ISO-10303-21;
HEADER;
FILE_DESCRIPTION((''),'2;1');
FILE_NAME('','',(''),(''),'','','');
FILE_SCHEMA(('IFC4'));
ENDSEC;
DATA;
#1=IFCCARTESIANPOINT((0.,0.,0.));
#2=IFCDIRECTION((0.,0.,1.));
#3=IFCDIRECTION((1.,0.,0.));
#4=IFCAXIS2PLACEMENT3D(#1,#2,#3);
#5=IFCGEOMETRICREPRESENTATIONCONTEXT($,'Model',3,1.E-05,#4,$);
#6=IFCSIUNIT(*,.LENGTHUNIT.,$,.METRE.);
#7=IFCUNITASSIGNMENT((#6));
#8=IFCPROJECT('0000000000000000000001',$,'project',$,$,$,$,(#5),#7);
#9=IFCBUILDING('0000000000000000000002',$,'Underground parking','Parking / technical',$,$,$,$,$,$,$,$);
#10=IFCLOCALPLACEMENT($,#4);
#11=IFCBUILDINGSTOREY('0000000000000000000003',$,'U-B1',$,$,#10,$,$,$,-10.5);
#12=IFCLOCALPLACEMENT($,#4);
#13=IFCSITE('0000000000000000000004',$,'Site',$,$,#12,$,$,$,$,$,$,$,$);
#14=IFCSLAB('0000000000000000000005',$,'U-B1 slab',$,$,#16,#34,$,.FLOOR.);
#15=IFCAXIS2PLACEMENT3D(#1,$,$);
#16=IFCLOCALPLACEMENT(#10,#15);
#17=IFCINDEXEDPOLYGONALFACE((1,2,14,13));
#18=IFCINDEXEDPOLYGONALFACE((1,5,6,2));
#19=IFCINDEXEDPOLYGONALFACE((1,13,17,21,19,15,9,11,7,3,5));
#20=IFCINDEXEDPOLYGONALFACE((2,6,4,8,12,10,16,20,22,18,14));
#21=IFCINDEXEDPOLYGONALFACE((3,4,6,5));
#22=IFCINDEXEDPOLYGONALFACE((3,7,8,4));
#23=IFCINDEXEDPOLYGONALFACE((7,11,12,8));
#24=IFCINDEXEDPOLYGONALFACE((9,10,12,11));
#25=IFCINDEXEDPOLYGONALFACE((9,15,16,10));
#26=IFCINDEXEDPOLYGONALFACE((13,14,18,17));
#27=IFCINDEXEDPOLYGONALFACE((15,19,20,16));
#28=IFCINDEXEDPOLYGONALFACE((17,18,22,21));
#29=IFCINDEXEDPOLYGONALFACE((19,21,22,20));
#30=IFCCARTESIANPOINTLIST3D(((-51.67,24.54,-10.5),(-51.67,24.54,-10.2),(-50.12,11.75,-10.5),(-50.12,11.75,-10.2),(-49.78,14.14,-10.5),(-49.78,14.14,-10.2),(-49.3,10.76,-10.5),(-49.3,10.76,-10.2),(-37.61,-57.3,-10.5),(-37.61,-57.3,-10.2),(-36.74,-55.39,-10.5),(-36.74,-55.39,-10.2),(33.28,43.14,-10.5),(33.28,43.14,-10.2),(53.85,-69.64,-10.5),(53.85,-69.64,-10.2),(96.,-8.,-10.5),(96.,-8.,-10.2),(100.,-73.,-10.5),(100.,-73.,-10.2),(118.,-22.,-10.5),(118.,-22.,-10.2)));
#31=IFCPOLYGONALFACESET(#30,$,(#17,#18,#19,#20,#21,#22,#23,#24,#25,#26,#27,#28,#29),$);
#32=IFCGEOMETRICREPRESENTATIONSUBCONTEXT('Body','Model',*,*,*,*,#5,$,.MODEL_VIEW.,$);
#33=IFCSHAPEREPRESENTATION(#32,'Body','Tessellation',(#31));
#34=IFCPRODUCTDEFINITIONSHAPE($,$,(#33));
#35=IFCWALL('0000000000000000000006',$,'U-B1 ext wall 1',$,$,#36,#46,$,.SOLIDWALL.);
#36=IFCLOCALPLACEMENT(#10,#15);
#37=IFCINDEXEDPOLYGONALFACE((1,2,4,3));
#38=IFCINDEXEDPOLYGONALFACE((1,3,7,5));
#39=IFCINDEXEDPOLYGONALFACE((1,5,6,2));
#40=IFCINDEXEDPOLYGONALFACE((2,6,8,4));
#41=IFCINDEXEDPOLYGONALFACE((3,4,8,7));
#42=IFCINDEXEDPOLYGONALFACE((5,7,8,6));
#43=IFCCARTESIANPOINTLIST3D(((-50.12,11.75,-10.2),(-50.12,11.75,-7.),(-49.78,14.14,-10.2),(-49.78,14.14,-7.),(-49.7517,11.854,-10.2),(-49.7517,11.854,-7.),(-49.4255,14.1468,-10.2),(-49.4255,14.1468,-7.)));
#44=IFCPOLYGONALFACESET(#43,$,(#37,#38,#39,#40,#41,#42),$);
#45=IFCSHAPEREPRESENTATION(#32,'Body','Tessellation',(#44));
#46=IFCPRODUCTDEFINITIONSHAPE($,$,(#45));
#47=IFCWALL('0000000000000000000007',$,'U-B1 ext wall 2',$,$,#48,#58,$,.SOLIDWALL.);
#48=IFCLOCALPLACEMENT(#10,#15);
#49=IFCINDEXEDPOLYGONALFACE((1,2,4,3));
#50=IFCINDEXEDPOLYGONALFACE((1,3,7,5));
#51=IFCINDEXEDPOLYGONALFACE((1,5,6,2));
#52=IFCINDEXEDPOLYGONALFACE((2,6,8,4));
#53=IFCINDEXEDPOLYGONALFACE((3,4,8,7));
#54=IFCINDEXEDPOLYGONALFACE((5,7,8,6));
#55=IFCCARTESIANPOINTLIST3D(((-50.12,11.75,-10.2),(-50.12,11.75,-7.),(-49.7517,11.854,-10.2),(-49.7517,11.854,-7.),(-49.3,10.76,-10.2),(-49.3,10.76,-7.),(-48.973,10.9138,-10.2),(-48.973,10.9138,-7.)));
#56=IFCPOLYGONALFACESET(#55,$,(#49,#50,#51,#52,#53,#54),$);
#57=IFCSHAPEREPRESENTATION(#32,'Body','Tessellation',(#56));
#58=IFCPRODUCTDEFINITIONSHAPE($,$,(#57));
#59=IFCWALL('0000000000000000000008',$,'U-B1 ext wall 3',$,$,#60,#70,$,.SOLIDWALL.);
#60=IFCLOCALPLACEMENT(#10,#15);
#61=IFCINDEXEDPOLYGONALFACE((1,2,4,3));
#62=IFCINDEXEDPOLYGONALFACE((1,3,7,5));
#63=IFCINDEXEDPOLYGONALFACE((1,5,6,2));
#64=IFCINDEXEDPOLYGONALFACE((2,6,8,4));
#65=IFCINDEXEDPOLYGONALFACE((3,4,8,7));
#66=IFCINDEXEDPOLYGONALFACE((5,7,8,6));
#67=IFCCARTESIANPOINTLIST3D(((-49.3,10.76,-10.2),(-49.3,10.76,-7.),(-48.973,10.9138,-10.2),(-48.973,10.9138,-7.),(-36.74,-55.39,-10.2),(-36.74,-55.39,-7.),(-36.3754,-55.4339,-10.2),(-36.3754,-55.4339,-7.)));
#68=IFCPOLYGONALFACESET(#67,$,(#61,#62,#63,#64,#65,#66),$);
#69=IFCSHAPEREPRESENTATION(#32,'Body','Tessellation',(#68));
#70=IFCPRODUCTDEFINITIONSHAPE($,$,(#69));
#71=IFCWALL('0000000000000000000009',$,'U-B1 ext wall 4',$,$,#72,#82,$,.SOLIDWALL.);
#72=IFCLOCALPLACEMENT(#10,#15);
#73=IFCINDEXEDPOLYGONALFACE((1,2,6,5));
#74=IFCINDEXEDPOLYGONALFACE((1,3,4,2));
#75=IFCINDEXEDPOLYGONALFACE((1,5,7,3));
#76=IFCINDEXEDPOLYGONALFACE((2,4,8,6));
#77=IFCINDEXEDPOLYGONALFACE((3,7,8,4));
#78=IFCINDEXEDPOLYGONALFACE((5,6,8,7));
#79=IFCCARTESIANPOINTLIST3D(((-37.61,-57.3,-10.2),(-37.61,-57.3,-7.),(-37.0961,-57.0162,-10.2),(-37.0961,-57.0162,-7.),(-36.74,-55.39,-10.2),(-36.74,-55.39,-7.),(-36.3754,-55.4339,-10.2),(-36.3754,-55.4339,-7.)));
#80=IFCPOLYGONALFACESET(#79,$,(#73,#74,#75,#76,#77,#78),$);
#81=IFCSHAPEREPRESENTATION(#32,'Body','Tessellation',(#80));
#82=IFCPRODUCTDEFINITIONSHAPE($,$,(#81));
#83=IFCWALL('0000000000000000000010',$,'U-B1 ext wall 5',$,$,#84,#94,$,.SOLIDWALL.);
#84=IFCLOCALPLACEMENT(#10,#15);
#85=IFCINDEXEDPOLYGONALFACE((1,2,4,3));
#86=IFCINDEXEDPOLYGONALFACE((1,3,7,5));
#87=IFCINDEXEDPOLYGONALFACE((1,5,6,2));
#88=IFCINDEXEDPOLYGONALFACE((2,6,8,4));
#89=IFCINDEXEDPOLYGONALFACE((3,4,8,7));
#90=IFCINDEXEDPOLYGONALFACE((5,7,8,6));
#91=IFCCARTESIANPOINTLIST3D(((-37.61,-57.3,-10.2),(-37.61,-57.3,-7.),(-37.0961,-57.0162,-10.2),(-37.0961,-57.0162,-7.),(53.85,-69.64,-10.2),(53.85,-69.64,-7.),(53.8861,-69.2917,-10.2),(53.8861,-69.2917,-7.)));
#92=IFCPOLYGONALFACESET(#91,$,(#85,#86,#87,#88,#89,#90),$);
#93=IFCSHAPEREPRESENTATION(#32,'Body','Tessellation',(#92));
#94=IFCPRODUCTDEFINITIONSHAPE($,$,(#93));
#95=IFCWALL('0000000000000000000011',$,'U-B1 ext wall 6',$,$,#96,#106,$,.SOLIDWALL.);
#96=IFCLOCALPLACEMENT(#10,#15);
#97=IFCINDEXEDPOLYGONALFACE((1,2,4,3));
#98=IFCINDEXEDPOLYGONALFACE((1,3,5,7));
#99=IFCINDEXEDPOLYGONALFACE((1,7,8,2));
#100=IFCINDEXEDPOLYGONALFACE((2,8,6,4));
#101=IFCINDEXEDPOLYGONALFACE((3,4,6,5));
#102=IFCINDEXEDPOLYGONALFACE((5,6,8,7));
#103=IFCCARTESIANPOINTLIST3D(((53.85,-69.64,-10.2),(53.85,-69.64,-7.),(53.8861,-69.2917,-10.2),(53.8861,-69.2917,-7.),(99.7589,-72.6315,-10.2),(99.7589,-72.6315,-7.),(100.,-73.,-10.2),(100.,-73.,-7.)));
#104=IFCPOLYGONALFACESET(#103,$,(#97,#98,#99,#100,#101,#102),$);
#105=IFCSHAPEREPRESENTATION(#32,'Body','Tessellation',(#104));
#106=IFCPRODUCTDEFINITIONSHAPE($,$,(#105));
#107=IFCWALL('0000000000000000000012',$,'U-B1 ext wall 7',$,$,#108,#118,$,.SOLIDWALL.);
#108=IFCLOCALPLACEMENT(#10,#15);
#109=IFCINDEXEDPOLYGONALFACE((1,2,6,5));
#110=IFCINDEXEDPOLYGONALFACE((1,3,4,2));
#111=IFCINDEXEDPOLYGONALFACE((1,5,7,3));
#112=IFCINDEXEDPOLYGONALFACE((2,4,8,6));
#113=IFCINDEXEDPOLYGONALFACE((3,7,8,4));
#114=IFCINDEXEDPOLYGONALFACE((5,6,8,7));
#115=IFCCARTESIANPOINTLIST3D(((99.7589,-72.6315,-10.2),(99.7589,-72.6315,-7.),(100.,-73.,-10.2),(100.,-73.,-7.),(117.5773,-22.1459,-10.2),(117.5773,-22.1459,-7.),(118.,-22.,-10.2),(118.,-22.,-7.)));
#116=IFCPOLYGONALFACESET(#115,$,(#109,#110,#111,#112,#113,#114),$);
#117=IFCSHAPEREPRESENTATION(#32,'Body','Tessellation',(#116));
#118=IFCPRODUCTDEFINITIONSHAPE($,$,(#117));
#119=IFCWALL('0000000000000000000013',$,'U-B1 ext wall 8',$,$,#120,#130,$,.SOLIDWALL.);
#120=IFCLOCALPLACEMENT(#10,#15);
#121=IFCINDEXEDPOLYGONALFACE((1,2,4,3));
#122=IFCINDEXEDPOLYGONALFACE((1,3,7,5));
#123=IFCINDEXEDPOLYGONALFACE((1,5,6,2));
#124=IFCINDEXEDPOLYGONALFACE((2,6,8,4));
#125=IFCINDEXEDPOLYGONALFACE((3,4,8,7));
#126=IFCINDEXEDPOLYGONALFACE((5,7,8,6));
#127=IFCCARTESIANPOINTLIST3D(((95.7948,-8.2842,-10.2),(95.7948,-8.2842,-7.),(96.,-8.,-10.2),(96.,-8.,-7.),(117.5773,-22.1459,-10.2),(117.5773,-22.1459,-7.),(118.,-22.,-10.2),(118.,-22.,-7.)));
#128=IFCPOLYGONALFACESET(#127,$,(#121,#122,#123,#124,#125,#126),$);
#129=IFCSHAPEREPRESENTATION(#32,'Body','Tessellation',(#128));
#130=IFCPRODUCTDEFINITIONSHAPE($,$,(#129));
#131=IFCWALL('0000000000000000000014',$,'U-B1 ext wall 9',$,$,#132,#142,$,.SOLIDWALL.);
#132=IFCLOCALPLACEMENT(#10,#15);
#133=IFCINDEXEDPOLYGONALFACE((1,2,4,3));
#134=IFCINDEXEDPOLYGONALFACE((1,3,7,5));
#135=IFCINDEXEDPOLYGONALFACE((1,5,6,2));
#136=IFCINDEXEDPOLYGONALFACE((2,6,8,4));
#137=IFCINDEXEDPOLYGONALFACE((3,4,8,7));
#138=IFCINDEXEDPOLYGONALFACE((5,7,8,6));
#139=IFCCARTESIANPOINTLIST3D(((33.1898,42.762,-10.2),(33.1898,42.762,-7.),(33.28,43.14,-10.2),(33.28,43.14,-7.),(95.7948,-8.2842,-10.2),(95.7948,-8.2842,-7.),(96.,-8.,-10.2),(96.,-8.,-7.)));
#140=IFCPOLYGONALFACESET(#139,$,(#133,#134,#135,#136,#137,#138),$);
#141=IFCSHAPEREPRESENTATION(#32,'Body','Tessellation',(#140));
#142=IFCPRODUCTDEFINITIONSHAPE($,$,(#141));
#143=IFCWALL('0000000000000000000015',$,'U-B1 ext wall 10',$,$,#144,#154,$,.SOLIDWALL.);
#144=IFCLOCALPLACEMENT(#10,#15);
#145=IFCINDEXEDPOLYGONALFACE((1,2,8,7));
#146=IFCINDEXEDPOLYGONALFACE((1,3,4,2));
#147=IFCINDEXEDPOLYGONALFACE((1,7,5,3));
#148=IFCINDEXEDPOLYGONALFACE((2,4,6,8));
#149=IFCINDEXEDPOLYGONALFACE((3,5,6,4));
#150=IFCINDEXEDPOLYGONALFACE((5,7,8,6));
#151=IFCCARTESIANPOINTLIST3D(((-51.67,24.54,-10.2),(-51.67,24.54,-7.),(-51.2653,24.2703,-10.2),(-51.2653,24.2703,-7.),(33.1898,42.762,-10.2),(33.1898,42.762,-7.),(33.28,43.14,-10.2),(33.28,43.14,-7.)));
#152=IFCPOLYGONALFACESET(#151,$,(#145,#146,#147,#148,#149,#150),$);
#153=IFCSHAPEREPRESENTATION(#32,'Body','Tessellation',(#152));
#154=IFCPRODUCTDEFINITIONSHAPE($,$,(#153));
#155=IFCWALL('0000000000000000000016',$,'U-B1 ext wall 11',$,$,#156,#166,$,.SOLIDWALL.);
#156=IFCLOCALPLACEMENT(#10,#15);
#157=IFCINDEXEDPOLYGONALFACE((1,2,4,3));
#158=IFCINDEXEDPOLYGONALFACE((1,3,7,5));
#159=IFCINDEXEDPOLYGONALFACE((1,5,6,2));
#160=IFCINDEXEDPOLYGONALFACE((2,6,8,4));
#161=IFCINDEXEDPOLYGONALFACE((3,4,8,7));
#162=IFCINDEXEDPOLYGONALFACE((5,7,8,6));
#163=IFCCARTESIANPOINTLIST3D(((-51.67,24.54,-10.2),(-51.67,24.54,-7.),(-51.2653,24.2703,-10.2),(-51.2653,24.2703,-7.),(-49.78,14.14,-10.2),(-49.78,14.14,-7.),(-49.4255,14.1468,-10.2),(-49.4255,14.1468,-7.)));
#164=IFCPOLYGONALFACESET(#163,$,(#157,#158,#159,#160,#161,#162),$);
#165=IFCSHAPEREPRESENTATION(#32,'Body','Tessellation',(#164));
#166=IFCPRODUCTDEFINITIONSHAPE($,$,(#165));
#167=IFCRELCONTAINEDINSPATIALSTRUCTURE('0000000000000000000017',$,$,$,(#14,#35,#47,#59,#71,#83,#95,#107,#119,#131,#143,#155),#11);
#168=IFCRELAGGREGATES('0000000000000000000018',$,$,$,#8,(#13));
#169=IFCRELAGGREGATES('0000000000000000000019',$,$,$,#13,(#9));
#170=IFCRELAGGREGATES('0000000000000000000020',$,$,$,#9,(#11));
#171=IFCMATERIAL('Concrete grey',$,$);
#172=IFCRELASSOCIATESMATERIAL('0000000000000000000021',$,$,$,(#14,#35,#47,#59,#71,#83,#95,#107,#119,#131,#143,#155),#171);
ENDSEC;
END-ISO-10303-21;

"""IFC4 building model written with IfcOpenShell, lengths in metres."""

from ifc_helpers import new_model, si_unit, frame, origin_with_axes, place, context, subcontext, project, spatial, polyline, outline, extrude, material, element, save


model = new_model("IFC4")

# Units and contexts
model_context = context("Model", 3, precision=1e-05, world=origin_with_axes())
body_context = subcontext(model_context, "Body", "Model", "MODEL_VIEW")
ifc_project = project(units=[si_unit("LENGTHUNIT", "METRE")], contexts=[model_context])

# Site, building, storey
site_placement = place(None, origin_with_axes())
site = spatial("IfcSite", under=ifc_project, at=site_placement, Name="Site")
building = spatial("IfcBuilding", under=site, Name="Underground parking", Description="Parking / technical")
storey_placement = place(None, origin_with_axes())
storey = spatial("IfcBuildingStorey", under=building, at=storey_placement, Name="U-B1", Elevation=-10.5)

# Slab
ifc_material = material(Name="Concrete grey")
slab_placement = place(storey_placement, origin_with_axes())
element("IfcSlab", 1, at=slab_placement, inside=storey, material=ifc_material, Name="U-B1 slab", PredefinedType="FLOOR", context=body_context, shape_type="SweptSolid", body=[
    extrude(outline(polyline([(-49.78, 14.14), (-50.12, 11.75), (-49.3, 10.76), (-36.74, -55.39), (-37.61, -57.3), (53.85, -69.64), (100.0, -73.0), (118.0, -22.0), (96.0, -8.0), (33.28, 43.14), (-51.67, 24.54), (-49.78, 14.14)])), frame((0.0, 0.0, -10.5), z_axis=(0.0, 0.0, 1.0), x_axis=(1.0, 0.0, 0.0)), (0.0, 0.0, 1.0), 0.3),
])

# Walls
wall_1_placement = place(storey_placement, origin_with_axes())
element("IfcWall", 2, at=wall_1_placement, inside=storey, material=ifc_material, Name="U-B1 ext wall 1", PredefinedType="SOLIDWALL", context=body_context, shape_type="SweptSolid", body=[
    extrude(outline(polyline([(-49.78, 14.14), (-50.12, 11.75), (-49.7517, 11.854), (-49.4255, 14.1468), (-49.78, 14.14)])), frame((0.0, 0.0, -10.2), z_axis=(0.0, 0.0, 1.0), x_axis=(1.0, 0.0, 0.0)), (0.0, 0.0, 1.0), 3.2),
])
wall_2_placement = place(storey_placement, origin_with_axes())
element("IfcWall", 3, at=wall_2_placement, inside=storey, material=ifc_material, Name="U-B1 ext wall 2", PredefinedType="SOLIDWALL", context=body_context, shape_type="SweptSolid", body=[
    extrude(outline(polyline([(-50.12, 11.75), (-49.3, 10.76), (-48.973, 10.9138), (-49.7517, 11.854), (-50.12, 11.75)])), frame((0.0, 0.0, -10.2), z_axis=(0.0, 0.0, 1.0), x_axis=(1.0, 0.0, 0.0)), (0.0, 0.0, 1.0), 3.2),
])
wall_3_placement = place(storey_placement, origin_with_axes())
element("IfcWall", 4, at=wall_3_placement, inside=storey, material=ifc_material, Name="U-B1 ext wall 3", PredefinedType="SOLIDWALL", context=body_context, shape_type="SweptSolid", body=[
    extrude(outline(polyline([(-49.3, 10.76), (-36.74, -55.39), (-36.3754, -55.4339), (-48.973, 10.9138), (-49.3, 10.76)])), frame((0.0, 0.0, -10.2), z_axis=(0.0, 0.0, 1.0), x_axis=(1.0, 0.0, 0.0)), (0.0, 0.0, 1.0), 3.2),
])
wall_4_placement = place(storey_placement, origin_with_axes())
element("IfcWall", 5, at=wall_4_placement, inside=storey, material=ifc_material, Name="U-B1 ext wall 4", PredefinedType="SOLIDWALL", context=body_context, shape_type="SweptSolid", body=[
    extrude(outline(polyline([(-36.74, -55.39), (-37.61, -57.3), (-37.0961, -57.0162), (-36.3754, -55.4339), (-36.74, -55.39)])), frame((0.0, 0.0, -10.2), z_axis=(0.0, 0.0, 1.0), x_axis=(1.0, 0.0, 0.0)), (0.0, 0.0, 1.0), 3.2),
])
wall_5_placement = place(storey_placement, origin_with_axes())
element("IfcWall", 6, at=wall_5_placement, inside=storey, material=ifc_material, Name="U-B1 ext wall 5", PredefinedType="SOLIDWALL", context=body_context, shape_type="SweptSolid", body=[
    extrude(outline(polyline([(-37.61, -57.3), (53.85, -69.64), (53.8861, -69.2917), (-37.0961, -57.0162), (-37.61, -57.3)])), frame((0.0, 0.0, -10.2), z_axis=(0.0, 0.0, 1.0), x_axis=(1.0, 0.0, 0.0)), (0.0, 0.0, 1.0), 3.2),
])
wall_6_placement = place(storey_placement, origin_with_axes())
element("IfcWall", 7, at=wall_6_placement, inside=storey, material=ifc_material, Name="U-B1 ext wall 6", PredefinedType="SOLIDWALL", context=body_context, shape_type="SweptSolid", body=[
    extrude(outline(polyline([(53.85, -69.64), (100.0, -73.0), (99.7589, -72.6315), (53.8861, -69.2917), (53.85, -69.64)])), frame((0.0, 0.0, -10.2), z_axis=(0.0, 0.0, 1.0), x_axis=(1.0, 0.0, 0.0)), (0.0, 0.0, 1.0), 3.2),
])
wall_7_placement = place(storey_placement, origin_with_axes())
element("IfcWall", 8, at=wall_7_placement, inside=storey, material=ifc_material, Name="U-B1 ext wall 7", PredefinedType="SOLIDWALL", context=body_context, shape_type="SweptSolid", body=[
    extrude(outline(polyline([(100.0, -73.0), (118.0, -22.0), (117.5773, -22.1459), (99.7589, -72.6315), (100.0, -73.0)])), frame((0.0, 0.0, -10.2), z_axis=(0.0, 0.0, 1.0), x_axis=(1.0, 0.0, 0.0)), (0.0, 0.0, 1.0), 3.2),
])
wall_8_placement = place(storey_placement, origin_with_axes())
element("IfcWall", 9, at=wall_8_placement, inside=storey, material=ifc_material, Name="U-B1 ext wall 8", PredefinedType="SOLIDWALL", context=body_context, shape_type="SweptSolid", body=[
    extrude(outline(polyline([(118.0, -22.0), (96.0, -8.0), (95.7948, -8.2842), (117.5773, -22.1459), (118.0, -22.0)])), frame((0.0, 0.0, -10.2), z_axis=(0.0, 0.0, 1.0), x_axis=(1.0, 0.0, 0.0)), (0.0, 0.0, 1.0), 3.2),
])
wall_9_placement = place(storey_placement, origin_with_axes())
element("IfcWall", 10, at=wall_9_placement, inside=storey, material=ifc_material, Name="U-B1 ext wall 9", PredefinedType="SOLIDWALL", context=body_context, shape_type="SweptSolid", body=[
    extrude(outline(polyline([(96.0, -8.0), (33.28, 43.14), (33.1898, 42.762), (95.7948, -8.2842), (96.0, -8.0)])), frame((0.0, 0.0, -10.2), z_axis=(0.0, 0.0, 1.0), x_axis=(1.0, 0.0, 0.0)), (0.0, 0.0, 1.0), 3.2),
])
wall_10_placement = place(storey_placement, origin_with_axes())
element("IfcWall", 11, at=wall_10_placement, inside=storey, material=ifc_material, Name="U-B1 ext wall 10", PredefinedType="SOLIDWALL", context=body_context, shape_type="SweptSolid", body=[
    extrude(outline(polyline([(33.28, 43.14), (-51.67, 24.54), (-51.2653, 24.2703), (33.1898, 42.762), (33.28, 43.14)])), frame((0.0, 0.0, -10.2), z_axis=(0.0, 0.0, 1.0), x_axis=(1.0, 0.0, 0.0)), (0.0, 0.0, 1.0), 3.2),
])
wall_11_placement = place(storey_placement, origin_with_axes())
element("IfcWall", 12, at=wall_11_placement, inside=storey, material=ifc_material, Name="U-B1 ext wall 11", PredefinedType="SOLIDWALL", context=body_context, shape_type="SweptSolid", body=[
    extrude(outline(polyline([(-51.67, 24.54), (-49.78, 14.14), (-49.4255, 14.1468), (-51.2653, 24.2703), (-51.67, 24.54)])), frame((0.0, 0.0, -10.2), z_axis=(0.0, 0.0, 1.0), x_axis=(1.0, 0.0, 0.0)), (0.0, 0.0, 1.0), 3.2),
])

save(model, "model.ifc")
